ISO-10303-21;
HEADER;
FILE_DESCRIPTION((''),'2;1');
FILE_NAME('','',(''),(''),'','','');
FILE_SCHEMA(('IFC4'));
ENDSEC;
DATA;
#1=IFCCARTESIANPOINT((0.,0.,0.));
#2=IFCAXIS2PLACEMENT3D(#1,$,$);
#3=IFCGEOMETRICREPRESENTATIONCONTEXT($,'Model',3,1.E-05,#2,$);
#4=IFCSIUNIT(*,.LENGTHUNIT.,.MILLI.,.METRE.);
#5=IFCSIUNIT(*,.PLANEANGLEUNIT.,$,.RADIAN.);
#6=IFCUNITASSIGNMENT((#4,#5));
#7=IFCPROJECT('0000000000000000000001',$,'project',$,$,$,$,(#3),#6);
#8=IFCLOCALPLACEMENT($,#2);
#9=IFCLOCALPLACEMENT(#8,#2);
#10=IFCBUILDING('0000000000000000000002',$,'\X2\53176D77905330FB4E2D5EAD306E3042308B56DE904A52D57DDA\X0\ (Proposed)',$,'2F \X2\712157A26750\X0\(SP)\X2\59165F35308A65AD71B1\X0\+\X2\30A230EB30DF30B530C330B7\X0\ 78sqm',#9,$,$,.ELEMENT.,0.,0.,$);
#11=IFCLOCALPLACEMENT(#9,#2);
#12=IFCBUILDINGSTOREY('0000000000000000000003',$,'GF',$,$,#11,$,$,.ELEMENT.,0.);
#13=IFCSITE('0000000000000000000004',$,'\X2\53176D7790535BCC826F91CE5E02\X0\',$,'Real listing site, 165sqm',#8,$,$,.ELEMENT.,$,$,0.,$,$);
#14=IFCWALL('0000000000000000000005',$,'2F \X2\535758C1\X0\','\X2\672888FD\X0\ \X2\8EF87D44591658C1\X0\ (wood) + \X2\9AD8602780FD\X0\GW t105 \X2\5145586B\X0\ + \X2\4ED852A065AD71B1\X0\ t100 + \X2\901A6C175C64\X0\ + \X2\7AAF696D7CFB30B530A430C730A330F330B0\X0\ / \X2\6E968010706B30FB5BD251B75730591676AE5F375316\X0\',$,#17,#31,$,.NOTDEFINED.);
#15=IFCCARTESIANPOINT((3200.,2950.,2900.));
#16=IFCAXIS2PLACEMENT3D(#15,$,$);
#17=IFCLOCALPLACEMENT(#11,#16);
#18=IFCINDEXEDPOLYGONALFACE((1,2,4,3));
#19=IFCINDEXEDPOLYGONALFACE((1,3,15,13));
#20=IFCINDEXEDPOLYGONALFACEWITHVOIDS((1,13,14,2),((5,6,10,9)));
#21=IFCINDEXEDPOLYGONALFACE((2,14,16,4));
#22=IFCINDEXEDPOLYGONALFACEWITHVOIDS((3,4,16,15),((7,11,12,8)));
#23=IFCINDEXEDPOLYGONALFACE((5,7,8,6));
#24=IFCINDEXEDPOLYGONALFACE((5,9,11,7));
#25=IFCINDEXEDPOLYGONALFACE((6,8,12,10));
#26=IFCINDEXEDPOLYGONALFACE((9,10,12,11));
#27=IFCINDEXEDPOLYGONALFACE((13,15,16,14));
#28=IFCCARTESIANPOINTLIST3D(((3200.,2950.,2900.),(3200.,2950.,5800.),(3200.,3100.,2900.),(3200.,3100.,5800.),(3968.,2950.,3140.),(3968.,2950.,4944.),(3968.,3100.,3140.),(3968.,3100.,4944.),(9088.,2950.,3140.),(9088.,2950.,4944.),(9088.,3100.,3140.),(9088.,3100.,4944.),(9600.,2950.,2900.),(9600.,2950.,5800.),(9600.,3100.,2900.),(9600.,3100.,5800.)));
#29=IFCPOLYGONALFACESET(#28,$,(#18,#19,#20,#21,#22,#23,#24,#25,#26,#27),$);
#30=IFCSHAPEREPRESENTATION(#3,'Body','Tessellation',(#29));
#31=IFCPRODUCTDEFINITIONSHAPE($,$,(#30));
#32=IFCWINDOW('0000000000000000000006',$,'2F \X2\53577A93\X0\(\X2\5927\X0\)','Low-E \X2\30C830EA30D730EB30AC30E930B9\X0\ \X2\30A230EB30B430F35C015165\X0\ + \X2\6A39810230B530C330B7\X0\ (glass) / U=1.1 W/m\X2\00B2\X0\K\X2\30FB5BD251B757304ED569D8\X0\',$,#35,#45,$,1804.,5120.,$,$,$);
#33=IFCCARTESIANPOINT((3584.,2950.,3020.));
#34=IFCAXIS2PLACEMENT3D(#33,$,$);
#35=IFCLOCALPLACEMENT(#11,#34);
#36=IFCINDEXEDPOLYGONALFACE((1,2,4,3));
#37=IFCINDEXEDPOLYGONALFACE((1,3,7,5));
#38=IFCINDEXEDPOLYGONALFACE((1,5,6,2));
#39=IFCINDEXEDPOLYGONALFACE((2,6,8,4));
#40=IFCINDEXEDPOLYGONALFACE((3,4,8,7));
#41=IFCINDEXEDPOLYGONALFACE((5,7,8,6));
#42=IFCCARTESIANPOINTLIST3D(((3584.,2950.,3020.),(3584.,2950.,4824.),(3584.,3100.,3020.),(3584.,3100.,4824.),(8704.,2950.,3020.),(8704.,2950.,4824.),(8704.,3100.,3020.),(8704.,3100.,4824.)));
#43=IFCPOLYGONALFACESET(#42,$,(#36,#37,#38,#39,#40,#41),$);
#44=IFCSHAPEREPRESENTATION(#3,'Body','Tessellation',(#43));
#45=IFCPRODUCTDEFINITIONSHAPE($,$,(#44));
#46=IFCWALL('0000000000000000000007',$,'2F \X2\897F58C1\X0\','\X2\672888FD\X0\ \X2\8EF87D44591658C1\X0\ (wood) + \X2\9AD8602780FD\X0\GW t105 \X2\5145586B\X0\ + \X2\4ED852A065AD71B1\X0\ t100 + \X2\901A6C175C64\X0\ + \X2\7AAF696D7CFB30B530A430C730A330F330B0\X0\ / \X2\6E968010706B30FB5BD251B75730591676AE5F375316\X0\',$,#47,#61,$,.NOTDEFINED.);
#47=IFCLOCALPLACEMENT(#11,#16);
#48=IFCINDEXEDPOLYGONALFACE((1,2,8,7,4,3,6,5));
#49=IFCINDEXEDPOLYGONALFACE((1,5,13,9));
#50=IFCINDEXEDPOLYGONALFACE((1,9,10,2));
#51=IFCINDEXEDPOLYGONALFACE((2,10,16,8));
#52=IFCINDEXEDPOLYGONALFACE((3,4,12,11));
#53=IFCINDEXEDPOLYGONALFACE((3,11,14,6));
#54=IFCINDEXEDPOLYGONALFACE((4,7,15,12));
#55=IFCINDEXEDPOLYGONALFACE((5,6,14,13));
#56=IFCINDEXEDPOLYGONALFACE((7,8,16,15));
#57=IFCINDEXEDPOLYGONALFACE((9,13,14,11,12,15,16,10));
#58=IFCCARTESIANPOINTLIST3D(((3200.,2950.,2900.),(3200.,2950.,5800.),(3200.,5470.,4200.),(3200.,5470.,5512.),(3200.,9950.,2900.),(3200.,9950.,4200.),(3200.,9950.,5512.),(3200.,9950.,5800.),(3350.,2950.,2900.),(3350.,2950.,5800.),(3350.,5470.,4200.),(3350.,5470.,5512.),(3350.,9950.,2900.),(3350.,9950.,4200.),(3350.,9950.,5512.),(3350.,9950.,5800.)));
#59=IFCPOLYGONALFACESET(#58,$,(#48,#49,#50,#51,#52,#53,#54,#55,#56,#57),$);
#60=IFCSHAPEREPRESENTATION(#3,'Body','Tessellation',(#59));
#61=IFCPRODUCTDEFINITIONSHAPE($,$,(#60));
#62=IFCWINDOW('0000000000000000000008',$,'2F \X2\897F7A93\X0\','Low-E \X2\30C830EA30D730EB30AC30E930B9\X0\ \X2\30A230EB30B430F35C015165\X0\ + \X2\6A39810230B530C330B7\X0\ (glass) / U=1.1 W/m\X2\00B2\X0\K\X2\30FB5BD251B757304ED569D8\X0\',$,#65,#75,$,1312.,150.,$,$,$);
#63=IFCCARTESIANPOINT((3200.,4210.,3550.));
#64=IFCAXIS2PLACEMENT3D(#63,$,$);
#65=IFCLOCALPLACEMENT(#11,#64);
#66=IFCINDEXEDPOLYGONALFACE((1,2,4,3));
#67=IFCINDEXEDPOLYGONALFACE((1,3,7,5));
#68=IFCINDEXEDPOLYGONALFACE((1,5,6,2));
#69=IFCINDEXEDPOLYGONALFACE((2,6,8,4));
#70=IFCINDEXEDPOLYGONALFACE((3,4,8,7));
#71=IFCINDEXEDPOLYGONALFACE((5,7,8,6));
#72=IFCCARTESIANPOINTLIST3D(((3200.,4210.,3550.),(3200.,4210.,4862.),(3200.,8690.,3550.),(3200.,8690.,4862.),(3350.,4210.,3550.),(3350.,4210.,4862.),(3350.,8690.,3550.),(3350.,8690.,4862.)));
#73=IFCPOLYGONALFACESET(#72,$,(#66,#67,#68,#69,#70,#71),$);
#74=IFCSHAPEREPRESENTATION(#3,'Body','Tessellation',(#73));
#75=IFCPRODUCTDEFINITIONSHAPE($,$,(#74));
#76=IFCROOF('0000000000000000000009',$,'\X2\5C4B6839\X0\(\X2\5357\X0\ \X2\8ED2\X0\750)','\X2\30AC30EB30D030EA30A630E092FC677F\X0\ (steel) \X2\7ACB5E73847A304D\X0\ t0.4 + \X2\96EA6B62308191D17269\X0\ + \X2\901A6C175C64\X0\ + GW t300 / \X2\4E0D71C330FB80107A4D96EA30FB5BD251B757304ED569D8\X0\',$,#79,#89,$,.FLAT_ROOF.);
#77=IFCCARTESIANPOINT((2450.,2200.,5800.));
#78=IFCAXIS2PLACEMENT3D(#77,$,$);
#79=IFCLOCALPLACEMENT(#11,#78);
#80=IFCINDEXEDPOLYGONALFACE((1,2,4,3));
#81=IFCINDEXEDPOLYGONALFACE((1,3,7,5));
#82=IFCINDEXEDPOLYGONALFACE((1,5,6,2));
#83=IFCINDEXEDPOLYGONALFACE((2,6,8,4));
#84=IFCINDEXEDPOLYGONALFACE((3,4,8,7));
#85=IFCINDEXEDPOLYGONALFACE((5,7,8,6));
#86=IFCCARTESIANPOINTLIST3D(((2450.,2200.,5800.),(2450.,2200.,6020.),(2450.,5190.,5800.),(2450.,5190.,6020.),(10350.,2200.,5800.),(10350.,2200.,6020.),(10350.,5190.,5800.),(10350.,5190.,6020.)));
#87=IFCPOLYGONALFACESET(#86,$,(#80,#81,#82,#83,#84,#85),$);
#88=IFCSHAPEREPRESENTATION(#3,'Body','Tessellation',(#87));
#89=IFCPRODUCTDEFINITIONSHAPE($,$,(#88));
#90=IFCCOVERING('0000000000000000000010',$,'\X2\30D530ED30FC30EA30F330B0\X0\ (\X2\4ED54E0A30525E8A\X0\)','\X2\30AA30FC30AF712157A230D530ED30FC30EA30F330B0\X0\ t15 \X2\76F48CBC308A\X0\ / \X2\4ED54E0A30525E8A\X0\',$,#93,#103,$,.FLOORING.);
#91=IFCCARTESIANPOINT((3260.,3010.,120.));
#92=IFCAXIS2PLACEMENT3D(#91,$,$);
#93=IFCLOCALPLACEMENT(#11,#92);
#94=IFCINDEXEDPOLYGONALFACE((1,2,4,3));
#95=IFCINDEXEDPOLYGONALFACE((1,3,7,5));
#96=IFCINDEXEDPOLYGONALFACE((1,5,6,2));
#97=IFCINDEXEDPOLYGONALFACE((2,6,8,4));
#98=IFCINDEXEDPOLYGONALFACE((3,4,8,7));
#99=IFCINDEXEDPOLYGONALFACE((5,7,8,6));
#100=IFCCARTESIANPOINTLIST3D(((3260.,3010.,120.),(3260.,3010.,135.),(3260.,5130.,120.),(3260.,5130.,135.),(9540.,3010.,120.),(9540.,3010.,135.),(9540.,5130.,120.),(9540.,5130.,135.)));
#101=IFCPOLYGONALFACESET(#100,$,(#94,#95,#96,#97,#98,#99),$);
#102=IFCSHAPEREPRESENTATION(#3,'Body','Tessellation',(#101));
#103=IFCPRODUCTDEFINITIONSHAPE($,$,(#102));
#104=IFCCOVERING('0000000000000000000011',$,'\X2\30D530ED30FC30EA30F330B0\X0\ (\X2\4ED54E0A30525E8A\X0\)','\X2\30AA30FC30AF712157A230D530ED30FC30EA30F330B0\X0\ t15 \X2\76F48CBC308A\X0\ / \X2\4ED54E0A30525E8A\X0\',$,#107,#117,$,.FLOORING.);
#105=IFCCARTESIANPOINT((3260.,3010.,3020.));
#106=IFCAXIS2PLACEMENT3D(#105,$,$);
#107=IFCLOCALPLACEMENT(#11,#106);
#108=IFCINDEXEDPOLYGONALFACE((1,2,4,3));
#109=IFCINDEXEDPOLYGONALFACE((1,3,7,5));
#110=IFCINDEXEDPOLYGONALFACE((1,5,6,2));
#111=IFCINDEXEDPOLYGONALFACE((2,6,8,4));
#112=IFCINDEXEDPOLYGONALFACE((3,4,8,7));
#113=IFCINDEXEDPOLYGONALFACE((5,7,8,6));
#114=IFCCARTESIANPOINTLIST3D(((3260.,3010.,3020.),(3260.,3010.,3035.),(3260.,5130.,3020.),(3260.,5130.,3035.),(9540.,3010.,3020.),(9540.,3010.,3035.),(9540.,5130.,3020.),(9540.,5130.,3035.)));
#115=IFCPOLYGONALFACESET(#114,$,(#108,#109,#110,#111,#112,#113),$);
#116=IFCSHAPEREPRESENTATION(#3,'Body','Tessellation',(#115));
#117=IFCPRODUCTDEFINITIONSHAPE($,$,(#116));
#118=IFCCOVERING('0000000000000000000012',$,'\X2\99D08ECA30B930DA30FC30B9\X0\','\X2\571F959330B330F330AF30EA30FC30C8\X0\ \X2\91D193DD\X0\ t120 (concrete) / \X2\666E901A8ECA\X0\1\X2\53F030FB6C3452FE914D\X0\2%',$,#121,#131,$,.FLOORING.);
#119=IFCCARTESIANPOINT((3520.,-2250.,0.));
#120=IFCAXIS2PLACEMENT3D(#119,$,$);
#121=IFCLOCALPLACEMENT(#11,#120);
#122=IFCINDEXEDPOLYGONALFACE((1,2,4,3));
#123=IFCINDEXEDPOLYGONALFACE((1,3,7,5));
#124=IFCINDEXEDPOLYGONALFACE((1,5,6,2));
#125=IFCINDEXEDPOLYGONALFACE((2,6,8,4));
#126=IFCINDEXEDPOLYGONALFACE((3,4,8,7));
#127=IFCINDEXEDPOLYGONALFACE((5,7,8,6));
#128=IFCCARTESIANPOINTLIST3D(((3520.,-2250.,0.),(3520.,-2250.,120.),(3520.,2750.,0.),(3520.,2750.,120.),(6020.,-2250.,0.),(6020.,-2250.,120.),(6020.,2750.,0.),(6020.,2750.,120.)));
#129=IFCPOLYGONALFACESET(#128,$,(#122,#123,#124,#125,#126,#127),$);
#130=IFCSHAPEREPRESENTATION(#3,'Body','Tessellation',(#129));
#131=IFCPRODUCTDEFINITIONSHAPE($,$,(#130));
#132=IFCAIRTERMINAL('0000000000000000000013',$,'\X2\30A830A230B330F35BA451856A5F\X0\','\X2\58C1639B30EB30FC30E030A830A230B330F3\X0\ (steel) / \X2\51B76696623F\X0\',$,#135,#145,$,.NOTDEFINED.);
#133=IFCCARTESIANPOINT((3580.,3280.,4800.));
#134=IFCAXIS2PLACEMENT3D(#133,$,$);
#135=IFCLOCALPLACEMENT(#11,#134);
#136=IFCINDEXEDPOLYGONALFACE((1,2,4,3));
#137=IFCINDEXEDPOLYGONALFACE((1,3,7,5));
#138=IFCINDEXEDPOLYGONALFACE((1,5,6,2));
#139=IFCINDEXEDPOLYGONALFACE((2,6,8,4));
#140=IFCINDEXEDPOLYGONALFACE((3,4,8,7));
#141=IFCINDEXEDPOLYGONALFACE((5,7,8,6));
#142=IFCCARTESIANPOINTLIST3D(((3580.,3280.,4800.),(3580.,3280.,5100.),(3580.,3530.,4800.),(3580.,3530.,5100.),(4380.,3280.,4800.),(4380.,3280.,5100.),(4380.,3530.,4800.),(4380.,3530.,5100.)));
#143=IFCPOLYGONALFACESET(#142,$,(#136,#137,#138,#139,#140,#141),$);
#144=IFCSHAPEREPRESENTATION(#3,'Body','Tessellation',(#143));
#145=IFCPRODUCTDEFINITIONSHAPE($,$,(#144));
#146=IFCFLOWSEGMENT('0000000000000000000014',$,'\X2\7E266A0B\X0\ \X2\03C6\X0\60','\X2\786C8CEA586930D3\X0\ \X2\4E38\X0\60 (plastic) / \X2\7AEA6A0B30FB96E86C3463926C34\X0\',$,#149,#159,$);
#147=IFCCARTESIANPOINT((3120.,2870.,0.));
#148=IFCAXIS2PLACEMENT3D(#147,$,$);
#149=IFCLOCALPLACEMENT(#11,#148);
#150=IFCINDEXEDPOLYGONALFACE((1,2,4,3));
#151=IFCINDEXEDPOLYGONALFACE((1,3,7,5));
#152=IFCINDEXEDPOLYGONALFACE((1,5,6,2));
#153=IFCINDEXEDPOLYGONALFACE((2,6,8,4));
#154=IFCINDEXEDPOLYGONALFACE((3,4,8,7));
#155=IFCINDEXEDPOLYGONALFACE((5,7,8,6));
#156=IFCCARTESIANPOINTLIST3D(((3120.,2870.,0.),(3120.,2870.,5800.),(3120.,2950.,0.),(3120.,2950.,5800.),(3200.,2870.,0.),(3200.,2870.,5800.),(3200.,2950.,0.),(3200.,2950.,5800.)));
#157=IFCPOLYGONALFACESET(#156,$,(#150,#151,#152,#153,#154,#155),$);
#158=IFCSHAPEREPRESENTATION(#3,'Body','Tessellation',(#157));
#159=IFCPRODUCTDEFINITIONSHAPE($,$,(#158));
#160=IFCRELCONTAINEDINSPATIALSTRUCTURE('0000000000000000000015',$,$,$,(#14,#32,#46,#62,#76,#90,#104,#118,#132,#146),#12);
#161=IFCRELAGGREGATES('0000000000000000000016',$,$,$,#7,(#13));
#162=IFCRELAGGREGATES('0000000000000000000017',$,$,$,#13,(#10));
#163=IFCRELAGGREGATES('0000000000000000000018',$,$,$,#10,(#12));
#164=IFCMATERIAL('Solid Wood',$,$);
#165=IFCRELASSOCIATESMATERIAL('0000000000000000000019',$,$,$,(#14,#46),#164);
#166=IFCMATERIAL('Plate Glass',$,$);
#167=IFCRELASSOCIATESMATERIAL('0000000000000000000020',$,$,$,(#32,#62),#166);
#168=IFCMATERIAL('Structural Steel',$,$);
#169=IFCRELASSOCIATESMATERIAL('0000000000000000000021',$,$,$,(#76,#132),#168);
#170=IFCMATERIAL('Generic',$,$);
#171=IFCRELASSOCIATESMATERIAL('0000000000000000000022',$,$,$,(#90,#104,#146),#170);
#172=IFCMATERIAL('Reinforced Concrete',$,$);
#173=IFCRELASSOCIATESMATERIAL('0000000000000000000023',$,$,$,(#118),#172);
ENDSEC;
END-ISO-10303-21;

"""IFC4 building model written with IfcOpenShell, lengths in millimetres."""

from ifc_helpers import new_model, si_unit, frame, frame_2d, origin, place, context, project, spatial, rectangle, extrude, material, element, fill, save


model = new_model("IFC4")

# Units and contexts
model_context = context("Model", 3, precision=1e-05, world=origin())
ifc_project = project(units=[si_unit("LENGTHUNIT", "METRE", prefix="MILLI"), si_unit("PLANEANGLEUNIT", "RADIAN")], contexts=[model_context])

# Site, building, storey
site_placement = place(None, origin())
site = spatial("IfcSite", under=ifc_project, at=site_placement, Name="北海道富良野市", ObjectType="Real listing site, 165sqm", CompositionType="ELEMENT", RefElevation=0.0)
building_placement = place(site_placement, origin())
building = spatial("IfcBuilding", under=site, at=building_placement, Name="北海道・中庭のある回遊動線 (Proposed)", ObjectType="2F 無垢材(SP)外張り断熱+アルミサッシ 78sqm", CompositionType="ELEMENT", ElevationOfRefHeight=0.0, ElevationOfTerrain=0.0)
storey_placement = place(building_placement, origin())
storey = spatial("IfcBuildingStorey", under=building, at=storey_placement, Name="GF", CompositionType="ELEMENT", Elevation=0.0)

# Shared definitions
ifc_material_1 = material(Name="Solid Wood")

# Shared definitions
ifc_material_2 = material(Name="Reinforced Concrete")

# Shared definitions
ifc_material_3 = material(Name="Plate Glass")

# Walls, openings, windows
wall_1_placement = place(storey_placement, frame((3200.0, 2950.0, 2900.0)))
wall_1 = element("IfcWall", 1, at=wall_1_placement, inside=storey, material=ifc_material_1, Name="2F 南壁", Description="木製 軸組外壁 (wood) + 高性能GW t105 充填 + 付加断熱 t100 + 通気層 + 窯業系サイディング / 準耐火・寒冷地外皮強化", PredefinedType="NOTDEFINED", context=model_context, shape_type="SweptSolid", body=[
    extrude(rectangle(XDim=6400.0, YDim=150.0, at=frame_2d((3200.0, 75.0))), frame((3200.0, 2950.0, 2900.0)), (0.0, 0.0, 1.0), 2900.0),
])
opening_1_placement = place(storey_placement, frame((3584.0, 2950.0, 3020.0)))
opening_1 = element("IfcOpeningElement", 2, at=opening_1_placement, cuts=wall_1, PredefinedType="NOTDEFINED", context=model_context, shape_type="SweptSolid", body=[
    extrude(rectangle(XDim=5120.0, YDim=150.0, at=frame_2d((2560.0, 75.0))), frame((3584.0, 2950.0, 3020.0)), (0.0, 0.0, 1.0), 1804.0),
])
window_1_placement = place(storey_placement, frame((3584.0, 2950.0, 3020.0)))
window_1 = element("IfcWindow", 3, at=window_1_placement, inside=storey, material=ifc_material_3, Name="2F 南窓(大)", Description="Low-E トリプルガラス アルゴン封入 + 樹脂サッシ (glass) / U=1.1 W/m²K・寒冷地仕様", OverallHeight=1804.0, OverallWidth=5120.0, context=model_context, shape_type="SweptSolid", body=[
    extrude(rectangle(XDim=5120.0, YDim=150.0, at=frame_2d((2560.0, 75.0))), frame((3584.0, 2950.0, 3020.0)), (0.0, 0.0, 1.0), 1804.0),
])
fill(opening_1, window_1)
wall_2_placement = place(storey_placement, frame((3200.0, 2950.0, 2900.0)))
wall_2 = element("IfcWall", 4, at=wall_2_placement, inside=storey, material=ifc_material_1, Name="2F 西壁", Description="木製 軸組外壁 (wood) + 高性能GW t105 充填 + 付加断熱 t100 + 通気層 + 窯業系サイディング / 準耐火・寒冷地外皮強化", PredefinedType="NOTDEFINED", context=model_context, shape_type="SweptSolid", body=[
    extrude(rectangle(XDim=150.0, YDim=7000.0, at=frame_2d((75.0, 3500.0))), frame((3200.0, 2950.0, 2900.0)), (0.0, 0.0, 1.0), 2900.0),
])
opening_2_placement = place(storey_placement, frame((3200.0, 4210.0, 3550.0)))
opening_2 = element("IfcOpeningElement", 5, at=opening_2_placement, cuts=wall_2, PredefinedType="NOTDEFINED", context=model_context, shape_type="SweptSolid", body=[
    extrude(rectangle(XDim=150.0, YDim=4480.0, at=frame_2d((75.0, 2240.0))), frame((3200.0, 4210.0, 3550.0)), (0.0, 0.0, 1.0), 1312.0),
])
window_2_placement = place(storey_placement, frame((3200.0, 4210.0, 3550.0)))
window_2 = element("IfcWindow", 6, at=window_2_placement, inside=storey, material=ifc_material_3, Name="2F 西窓", Description="Low-E トリプルガラス アルゴン封入 + 樹脂サッシ (glass) / U=1.1 W/m²K・寒冷地仕様", OverallHeight=1312.0, OverallWidth=150.0, context=model_context, shape_type="SweptSolid", body=[
    extrude(rectangle(XDim=150.0, YDim=4480.0, at=frame_2d((75.0, 2240.0))), frame((3200.0, 4210.0, 3550.0)), (0.0, 0.0, 1.0), 1312.0),
])
fill(opening_2, window_2)

# Roof
ifc_material_4 = material(Name="Structural Steel")
for number, where, name in (
    (7, (2450.0, 2200.0, 5800.0), "屋根(南 軒750)"),
):
    element("IfcRoof", number, at=place(storey_placement, frame(where)), inside=storey, material=ifc_material_4, Name=name, Description="ガルバリウム鋼板 (steel) 立平葺き t0.4 + 雪止め金物 + 通気層 + GW t300 / 不燃・耐積雪・寒冷地仕様", PredefinedType="FLAT_ROOF", context=model_context, shape_type="SweptSolid", body=[
        extrude(rectangle(XDim=7900.0, YDim=2990.0, at=frame_2d((3950.0, 1495.0))), frame((2450.0, 2200.0, 5800.0)), (0.0, 0.0, 1.0), 220.0),
    ])

# Coverings
ifc_material_5 = material(Name="Generic")
covering_1_placement = place(storey_placement, frame((3260.0, 3010.0, 120.0)))
element("IfcCovering", 8, at=covering_1_placement, inside=storey, material=ifc_material_5, Name="フローリング (仕上げ床)", Description="オーク無垢フローリング t15 直貼り / 仕上げ床", PredefinedType="FLOORING", context=model_context, shape_type="SweptSolid", body=[
    extrude(rectangle(XDim=6280.0, YDim=2120.0, at=frame_2d((3140.0, 1060.0))), frame((3260.0, 3010.0, 120.0)), (0.0, 0.0, 1.0), 15.0),
])
covering_2_placement = place(storey_placement, frame((3260.0, 3010.0, 3020.0)))
element("IfcCovering", 9, at=covering_2_placement, inside=storey, material=ifc_material_5, Name="フローリング (仕上げ床)", Description="オーク無垢フローリング t15 直貼り / 仕上げ床", PredefinedType="FLOORING", context=model_context, shape_type="SweptSolid", body=[
    extrude(rectangle(XDim=6280.0, YDim=2120.0, at=frame_2d((3140.0, 1060.0))), frame((3260.0, 3010.0, 3020.0)), (0.0, 0.0, 1.0), 15.0),
])
covering_3_placement = place(storey_placement, frame((3520.0, -2250.0, 0.0)))
element("IfcCovering", 10, at=covering_3_placement, inside=storey, material=ifc_material_2, Name="駐車スペース", Description="土間コンクリート 金鏝 t120 (concrete) / 普通車1台・水勾配2%", PredefinedType="FLOORING", context=model_context, shape_type="SweptSolid", body=[
    extrude(rectangle(XDim=2500.0, YDim=5000.0, at=frame_2d((1250.0, 2500.0))), frame((3520.0, -2250.0, 0.0)), (0.0, 0.0, 1.0), 120.0),
])

# Air terminal
air_terminal_placement = place(storey_placement, frame((3580.0, 3280.0, 4800.0)))
element("IfcAirTerminal", 11, at=air_terminal_placement, inside=storey, material=ifc_material_4, Name="エアコン室内機", Description="壁掛ルームエアコン (steel) / 冷暖房", PredefinedType="NOTDEFINED", context=model_context, shape_type="SweptSolid", body=[
    extrude(rectangle(XDim=800.0, YDim=250.0, at=frame_2d((400.0, 125.0))), frame((3580.0, 3280.0, 4800.0)), (0.0, 0.0, 1.0), 300.0),
])

# Flow segment
flow_segment_1_placement = place(storey_placement, frame((3120.0, 2870.0, 0.0)))
element("IfcFlowSegment", 12, at=flow_segment_1_placement, inside=storey, material=ifc_material_5, Name="縦樋 φ60", Description="硬質塩ビ 丸60 (plastic) / 竪樋・雨水排水", context=model_context, shape_type="SweptSolid", body=[
    extrude(rectangle(XDim=80.0, YDim=80.0, at=frame_2d((40.0, 40.0))), frame((3120.0, 2870.0, 0.0)), (0.0, 0.0, 1.0), 5800.0),
])

save(model, "model.ifc")
